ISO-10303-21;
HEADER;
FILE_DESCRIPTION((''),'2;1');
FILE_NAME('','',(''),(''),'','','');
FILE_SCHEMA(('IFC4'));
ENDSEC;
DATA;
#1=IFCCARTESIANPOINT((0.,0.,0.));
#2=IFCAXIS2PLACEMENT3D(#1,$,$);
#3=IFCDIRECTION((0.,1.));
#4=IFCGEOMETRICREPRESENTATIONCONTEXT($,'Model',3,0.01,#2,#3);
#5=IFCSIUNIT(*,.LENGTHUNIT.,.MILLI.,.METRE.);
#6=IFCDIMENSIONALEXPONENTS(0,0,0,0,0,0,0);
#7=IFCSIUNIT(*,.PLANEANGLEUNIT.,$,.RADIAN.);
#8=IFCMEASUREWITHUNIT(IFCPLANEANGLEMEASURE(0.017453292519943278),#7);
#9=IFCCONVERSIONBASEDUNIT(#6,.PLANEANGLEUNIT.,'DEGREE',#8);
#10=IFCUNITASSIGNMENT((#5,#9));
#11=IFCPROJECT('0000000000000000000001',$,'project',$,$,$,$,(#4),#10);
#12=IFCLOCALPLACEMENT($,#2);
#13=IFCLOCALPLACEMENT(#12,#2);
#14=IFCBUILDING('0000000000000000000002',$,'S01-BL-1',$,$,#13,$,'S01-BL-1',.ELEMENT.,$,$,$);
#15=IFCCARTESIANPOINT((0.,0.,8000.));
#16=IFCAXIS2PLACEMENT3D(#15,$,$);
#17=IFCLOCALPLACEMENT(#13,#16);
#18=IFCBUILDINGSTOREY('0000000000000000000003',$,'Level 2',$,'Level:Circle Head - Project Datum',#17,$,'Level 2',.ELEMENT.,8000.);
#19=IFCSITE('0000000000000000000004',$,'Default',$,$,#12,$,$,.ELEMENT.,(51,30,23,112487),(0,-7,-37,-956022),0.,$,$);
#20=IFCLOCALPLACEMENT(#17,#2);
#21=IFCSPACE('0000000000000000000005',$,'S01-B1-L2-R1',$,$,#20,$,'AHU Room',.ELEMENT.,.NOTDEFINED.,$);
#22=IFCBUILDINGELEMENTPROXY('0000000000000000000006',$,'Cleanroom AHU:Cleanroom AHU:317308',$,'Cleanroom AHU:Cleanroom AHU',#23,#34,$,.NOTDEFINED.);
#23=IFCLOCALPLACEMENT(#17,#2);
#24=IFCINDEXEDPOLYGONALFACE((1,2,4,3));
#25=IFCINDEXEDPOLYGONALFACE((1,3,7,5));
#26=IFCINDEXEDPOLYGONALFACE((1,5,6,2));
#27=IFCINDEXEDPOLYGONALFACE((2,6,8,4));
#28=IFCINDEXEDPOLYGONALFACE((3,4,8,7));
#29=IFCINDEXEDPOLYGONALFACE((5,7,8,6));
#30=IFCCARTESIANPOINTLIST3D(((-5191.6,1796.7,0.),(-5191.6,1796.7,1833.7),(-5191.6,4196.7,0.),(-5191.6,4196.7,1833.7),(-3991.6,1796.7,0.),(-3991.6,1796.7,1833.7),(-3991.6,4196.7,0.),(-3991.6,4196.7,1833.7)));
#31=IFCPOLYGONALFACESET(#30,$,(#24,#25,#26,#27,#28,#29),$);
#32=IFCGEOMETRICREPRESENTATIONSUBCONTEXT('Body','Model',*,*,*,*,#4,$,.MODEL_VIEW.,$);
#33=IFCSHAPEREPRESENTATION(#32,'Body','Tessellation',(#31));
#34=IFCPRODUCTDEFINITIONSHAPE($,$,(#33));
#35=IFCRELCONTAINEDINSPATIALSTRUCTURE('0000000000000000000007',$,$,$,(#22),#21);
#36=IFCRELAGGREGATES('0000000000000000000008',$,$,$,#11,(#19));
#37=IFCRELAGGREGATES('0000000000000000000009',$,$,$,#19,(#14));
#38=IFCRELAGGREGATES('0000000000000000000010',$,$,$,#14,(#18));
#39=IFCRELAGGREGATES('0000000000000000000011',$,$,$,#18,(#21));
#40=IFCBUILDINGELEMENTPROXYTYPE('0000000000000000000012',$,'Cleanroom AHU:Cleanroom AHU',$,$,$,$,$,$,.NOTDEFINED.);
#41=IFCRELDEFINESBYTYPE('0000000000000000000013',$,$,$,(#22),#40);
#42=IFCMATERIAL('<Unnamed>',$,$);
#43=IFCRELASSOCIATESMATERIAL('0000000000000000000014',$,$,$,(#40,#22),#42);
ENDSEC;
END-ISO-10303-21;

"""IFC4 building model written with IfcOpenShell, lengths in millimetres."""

from ifc_helpers import new_model, entity, si_unit, converted_unit, direction, frame, origin, place, context, subcontext, project, spatial, indexed_curve, outline, extrude, source, transform, mapped, material, type_object, type_shapes, element, save


model = new_model("IFC4")

# Units and contexts
model_context = context("Model", 3, precision=0.01, world=origin(), true_north=direction((0.0, 1.0)))
body_context = subcontext(model_context, "Body", "Model", "MODEL_VIEW")
ifc_project = project(units=[si_unit("LENGTHUNIT", "METRE", prefix="MILLI"), converted_unit("PLANEANGLEUNIT", "DEGREE", entity("IfcPlaneAngleMeasure", 0.017453292519943278), si_unit("PLANEANGLEUNIT", "RADIAN"), dimensions=[0, 0, 0, 0, 0, 0, 0])], contexts=[model_context])

# Site, building, storey
site_placement = place(None, origin())
site = spatial("IfcSite", under=ifc_project, at=site_placement, Name="Default", CompositionType="ELEMENT", RefLatitude=(51, 30, 23, 112487), RefLongitude=(0, -7, -37, -956022), RefElevation=0.0)
building_placement = place(site_placement, origin())
building = spatial("IfcBuilding", under=site, at=building_placement, Name="S01-BL-1", LongName="S01-BL-1", CompositionType="ELEMENT")
storey_placement = place(building_placement, frame((0.0, 0.0, 8000.0)))
storey = spatial("IfcBuildingStorey", under=building, at=storey_placement, Name="Level 2", ObjectType="Level:Circle Head - Project Datum", LongName="Level 2", CompositionType="ELEMENT", Elevation=8000.0)

# Shared definitions
ifc_material_1 = material(Name="<Unnamed>")

# Shared definitions
space_1_placement = place(storey_placement, origin())
space_1 = spatial("IfcSpace", under=storey, at=space_1_placement, Name="S01-B1-L2-R1", LongName="AHU Room", CompositionType="ELEMENT", PredefinedType="NOTDEFINED")

# Building element proxy
building_element_proxy_type = type_object("IfcBuildingElementProxyType", Name="Cleanroom AHU:Cleanroom AHU", PredefinedType="NOTDEFINED", material=ifc_material_1)
shared_shape_1 = source(origin(), body_context, "Body", "SweptSolid", [
    extrude(outline(indexed_curve([(-600.0, -1200.0), (600.0, -1200.0), (600.0, 1200.0), (-600.0, 1200.0), (-600.0, -1200.0)], self_intersect=False)), frame((-4591.6, 2996.7, 8000.0), z_axis=(0.0, 0.0, 1.0), x_axis=(-1.0, 0.0, 0.0)), (0.0, 0.0, 1.0), 1833.7),
])
type_shapes(building_element_proxy_type, [shared_shape_1])
proxy_placement = place(space_1_placement, frame((0.0, 0.0, -8000.0)))
element("IfcBuildingElementProxy", 1, at=proxy_placement, inside=space_1, type_object=building_element_proxy_type, material=ifc_material_1, Name="Cleanroom AHU:Cleanroom AHU:317308", ObjectType="Cleanroom AHU:Cleanroom AHU", PredefinedType="NOTDEFINED", context=body_context, shape_type="MappedRepresentation", body=[
    mapped(shared_shape_1, transform((0.0, 0.0, 0.0), scale=1.0)),
])

save(model, "model.ifc")
